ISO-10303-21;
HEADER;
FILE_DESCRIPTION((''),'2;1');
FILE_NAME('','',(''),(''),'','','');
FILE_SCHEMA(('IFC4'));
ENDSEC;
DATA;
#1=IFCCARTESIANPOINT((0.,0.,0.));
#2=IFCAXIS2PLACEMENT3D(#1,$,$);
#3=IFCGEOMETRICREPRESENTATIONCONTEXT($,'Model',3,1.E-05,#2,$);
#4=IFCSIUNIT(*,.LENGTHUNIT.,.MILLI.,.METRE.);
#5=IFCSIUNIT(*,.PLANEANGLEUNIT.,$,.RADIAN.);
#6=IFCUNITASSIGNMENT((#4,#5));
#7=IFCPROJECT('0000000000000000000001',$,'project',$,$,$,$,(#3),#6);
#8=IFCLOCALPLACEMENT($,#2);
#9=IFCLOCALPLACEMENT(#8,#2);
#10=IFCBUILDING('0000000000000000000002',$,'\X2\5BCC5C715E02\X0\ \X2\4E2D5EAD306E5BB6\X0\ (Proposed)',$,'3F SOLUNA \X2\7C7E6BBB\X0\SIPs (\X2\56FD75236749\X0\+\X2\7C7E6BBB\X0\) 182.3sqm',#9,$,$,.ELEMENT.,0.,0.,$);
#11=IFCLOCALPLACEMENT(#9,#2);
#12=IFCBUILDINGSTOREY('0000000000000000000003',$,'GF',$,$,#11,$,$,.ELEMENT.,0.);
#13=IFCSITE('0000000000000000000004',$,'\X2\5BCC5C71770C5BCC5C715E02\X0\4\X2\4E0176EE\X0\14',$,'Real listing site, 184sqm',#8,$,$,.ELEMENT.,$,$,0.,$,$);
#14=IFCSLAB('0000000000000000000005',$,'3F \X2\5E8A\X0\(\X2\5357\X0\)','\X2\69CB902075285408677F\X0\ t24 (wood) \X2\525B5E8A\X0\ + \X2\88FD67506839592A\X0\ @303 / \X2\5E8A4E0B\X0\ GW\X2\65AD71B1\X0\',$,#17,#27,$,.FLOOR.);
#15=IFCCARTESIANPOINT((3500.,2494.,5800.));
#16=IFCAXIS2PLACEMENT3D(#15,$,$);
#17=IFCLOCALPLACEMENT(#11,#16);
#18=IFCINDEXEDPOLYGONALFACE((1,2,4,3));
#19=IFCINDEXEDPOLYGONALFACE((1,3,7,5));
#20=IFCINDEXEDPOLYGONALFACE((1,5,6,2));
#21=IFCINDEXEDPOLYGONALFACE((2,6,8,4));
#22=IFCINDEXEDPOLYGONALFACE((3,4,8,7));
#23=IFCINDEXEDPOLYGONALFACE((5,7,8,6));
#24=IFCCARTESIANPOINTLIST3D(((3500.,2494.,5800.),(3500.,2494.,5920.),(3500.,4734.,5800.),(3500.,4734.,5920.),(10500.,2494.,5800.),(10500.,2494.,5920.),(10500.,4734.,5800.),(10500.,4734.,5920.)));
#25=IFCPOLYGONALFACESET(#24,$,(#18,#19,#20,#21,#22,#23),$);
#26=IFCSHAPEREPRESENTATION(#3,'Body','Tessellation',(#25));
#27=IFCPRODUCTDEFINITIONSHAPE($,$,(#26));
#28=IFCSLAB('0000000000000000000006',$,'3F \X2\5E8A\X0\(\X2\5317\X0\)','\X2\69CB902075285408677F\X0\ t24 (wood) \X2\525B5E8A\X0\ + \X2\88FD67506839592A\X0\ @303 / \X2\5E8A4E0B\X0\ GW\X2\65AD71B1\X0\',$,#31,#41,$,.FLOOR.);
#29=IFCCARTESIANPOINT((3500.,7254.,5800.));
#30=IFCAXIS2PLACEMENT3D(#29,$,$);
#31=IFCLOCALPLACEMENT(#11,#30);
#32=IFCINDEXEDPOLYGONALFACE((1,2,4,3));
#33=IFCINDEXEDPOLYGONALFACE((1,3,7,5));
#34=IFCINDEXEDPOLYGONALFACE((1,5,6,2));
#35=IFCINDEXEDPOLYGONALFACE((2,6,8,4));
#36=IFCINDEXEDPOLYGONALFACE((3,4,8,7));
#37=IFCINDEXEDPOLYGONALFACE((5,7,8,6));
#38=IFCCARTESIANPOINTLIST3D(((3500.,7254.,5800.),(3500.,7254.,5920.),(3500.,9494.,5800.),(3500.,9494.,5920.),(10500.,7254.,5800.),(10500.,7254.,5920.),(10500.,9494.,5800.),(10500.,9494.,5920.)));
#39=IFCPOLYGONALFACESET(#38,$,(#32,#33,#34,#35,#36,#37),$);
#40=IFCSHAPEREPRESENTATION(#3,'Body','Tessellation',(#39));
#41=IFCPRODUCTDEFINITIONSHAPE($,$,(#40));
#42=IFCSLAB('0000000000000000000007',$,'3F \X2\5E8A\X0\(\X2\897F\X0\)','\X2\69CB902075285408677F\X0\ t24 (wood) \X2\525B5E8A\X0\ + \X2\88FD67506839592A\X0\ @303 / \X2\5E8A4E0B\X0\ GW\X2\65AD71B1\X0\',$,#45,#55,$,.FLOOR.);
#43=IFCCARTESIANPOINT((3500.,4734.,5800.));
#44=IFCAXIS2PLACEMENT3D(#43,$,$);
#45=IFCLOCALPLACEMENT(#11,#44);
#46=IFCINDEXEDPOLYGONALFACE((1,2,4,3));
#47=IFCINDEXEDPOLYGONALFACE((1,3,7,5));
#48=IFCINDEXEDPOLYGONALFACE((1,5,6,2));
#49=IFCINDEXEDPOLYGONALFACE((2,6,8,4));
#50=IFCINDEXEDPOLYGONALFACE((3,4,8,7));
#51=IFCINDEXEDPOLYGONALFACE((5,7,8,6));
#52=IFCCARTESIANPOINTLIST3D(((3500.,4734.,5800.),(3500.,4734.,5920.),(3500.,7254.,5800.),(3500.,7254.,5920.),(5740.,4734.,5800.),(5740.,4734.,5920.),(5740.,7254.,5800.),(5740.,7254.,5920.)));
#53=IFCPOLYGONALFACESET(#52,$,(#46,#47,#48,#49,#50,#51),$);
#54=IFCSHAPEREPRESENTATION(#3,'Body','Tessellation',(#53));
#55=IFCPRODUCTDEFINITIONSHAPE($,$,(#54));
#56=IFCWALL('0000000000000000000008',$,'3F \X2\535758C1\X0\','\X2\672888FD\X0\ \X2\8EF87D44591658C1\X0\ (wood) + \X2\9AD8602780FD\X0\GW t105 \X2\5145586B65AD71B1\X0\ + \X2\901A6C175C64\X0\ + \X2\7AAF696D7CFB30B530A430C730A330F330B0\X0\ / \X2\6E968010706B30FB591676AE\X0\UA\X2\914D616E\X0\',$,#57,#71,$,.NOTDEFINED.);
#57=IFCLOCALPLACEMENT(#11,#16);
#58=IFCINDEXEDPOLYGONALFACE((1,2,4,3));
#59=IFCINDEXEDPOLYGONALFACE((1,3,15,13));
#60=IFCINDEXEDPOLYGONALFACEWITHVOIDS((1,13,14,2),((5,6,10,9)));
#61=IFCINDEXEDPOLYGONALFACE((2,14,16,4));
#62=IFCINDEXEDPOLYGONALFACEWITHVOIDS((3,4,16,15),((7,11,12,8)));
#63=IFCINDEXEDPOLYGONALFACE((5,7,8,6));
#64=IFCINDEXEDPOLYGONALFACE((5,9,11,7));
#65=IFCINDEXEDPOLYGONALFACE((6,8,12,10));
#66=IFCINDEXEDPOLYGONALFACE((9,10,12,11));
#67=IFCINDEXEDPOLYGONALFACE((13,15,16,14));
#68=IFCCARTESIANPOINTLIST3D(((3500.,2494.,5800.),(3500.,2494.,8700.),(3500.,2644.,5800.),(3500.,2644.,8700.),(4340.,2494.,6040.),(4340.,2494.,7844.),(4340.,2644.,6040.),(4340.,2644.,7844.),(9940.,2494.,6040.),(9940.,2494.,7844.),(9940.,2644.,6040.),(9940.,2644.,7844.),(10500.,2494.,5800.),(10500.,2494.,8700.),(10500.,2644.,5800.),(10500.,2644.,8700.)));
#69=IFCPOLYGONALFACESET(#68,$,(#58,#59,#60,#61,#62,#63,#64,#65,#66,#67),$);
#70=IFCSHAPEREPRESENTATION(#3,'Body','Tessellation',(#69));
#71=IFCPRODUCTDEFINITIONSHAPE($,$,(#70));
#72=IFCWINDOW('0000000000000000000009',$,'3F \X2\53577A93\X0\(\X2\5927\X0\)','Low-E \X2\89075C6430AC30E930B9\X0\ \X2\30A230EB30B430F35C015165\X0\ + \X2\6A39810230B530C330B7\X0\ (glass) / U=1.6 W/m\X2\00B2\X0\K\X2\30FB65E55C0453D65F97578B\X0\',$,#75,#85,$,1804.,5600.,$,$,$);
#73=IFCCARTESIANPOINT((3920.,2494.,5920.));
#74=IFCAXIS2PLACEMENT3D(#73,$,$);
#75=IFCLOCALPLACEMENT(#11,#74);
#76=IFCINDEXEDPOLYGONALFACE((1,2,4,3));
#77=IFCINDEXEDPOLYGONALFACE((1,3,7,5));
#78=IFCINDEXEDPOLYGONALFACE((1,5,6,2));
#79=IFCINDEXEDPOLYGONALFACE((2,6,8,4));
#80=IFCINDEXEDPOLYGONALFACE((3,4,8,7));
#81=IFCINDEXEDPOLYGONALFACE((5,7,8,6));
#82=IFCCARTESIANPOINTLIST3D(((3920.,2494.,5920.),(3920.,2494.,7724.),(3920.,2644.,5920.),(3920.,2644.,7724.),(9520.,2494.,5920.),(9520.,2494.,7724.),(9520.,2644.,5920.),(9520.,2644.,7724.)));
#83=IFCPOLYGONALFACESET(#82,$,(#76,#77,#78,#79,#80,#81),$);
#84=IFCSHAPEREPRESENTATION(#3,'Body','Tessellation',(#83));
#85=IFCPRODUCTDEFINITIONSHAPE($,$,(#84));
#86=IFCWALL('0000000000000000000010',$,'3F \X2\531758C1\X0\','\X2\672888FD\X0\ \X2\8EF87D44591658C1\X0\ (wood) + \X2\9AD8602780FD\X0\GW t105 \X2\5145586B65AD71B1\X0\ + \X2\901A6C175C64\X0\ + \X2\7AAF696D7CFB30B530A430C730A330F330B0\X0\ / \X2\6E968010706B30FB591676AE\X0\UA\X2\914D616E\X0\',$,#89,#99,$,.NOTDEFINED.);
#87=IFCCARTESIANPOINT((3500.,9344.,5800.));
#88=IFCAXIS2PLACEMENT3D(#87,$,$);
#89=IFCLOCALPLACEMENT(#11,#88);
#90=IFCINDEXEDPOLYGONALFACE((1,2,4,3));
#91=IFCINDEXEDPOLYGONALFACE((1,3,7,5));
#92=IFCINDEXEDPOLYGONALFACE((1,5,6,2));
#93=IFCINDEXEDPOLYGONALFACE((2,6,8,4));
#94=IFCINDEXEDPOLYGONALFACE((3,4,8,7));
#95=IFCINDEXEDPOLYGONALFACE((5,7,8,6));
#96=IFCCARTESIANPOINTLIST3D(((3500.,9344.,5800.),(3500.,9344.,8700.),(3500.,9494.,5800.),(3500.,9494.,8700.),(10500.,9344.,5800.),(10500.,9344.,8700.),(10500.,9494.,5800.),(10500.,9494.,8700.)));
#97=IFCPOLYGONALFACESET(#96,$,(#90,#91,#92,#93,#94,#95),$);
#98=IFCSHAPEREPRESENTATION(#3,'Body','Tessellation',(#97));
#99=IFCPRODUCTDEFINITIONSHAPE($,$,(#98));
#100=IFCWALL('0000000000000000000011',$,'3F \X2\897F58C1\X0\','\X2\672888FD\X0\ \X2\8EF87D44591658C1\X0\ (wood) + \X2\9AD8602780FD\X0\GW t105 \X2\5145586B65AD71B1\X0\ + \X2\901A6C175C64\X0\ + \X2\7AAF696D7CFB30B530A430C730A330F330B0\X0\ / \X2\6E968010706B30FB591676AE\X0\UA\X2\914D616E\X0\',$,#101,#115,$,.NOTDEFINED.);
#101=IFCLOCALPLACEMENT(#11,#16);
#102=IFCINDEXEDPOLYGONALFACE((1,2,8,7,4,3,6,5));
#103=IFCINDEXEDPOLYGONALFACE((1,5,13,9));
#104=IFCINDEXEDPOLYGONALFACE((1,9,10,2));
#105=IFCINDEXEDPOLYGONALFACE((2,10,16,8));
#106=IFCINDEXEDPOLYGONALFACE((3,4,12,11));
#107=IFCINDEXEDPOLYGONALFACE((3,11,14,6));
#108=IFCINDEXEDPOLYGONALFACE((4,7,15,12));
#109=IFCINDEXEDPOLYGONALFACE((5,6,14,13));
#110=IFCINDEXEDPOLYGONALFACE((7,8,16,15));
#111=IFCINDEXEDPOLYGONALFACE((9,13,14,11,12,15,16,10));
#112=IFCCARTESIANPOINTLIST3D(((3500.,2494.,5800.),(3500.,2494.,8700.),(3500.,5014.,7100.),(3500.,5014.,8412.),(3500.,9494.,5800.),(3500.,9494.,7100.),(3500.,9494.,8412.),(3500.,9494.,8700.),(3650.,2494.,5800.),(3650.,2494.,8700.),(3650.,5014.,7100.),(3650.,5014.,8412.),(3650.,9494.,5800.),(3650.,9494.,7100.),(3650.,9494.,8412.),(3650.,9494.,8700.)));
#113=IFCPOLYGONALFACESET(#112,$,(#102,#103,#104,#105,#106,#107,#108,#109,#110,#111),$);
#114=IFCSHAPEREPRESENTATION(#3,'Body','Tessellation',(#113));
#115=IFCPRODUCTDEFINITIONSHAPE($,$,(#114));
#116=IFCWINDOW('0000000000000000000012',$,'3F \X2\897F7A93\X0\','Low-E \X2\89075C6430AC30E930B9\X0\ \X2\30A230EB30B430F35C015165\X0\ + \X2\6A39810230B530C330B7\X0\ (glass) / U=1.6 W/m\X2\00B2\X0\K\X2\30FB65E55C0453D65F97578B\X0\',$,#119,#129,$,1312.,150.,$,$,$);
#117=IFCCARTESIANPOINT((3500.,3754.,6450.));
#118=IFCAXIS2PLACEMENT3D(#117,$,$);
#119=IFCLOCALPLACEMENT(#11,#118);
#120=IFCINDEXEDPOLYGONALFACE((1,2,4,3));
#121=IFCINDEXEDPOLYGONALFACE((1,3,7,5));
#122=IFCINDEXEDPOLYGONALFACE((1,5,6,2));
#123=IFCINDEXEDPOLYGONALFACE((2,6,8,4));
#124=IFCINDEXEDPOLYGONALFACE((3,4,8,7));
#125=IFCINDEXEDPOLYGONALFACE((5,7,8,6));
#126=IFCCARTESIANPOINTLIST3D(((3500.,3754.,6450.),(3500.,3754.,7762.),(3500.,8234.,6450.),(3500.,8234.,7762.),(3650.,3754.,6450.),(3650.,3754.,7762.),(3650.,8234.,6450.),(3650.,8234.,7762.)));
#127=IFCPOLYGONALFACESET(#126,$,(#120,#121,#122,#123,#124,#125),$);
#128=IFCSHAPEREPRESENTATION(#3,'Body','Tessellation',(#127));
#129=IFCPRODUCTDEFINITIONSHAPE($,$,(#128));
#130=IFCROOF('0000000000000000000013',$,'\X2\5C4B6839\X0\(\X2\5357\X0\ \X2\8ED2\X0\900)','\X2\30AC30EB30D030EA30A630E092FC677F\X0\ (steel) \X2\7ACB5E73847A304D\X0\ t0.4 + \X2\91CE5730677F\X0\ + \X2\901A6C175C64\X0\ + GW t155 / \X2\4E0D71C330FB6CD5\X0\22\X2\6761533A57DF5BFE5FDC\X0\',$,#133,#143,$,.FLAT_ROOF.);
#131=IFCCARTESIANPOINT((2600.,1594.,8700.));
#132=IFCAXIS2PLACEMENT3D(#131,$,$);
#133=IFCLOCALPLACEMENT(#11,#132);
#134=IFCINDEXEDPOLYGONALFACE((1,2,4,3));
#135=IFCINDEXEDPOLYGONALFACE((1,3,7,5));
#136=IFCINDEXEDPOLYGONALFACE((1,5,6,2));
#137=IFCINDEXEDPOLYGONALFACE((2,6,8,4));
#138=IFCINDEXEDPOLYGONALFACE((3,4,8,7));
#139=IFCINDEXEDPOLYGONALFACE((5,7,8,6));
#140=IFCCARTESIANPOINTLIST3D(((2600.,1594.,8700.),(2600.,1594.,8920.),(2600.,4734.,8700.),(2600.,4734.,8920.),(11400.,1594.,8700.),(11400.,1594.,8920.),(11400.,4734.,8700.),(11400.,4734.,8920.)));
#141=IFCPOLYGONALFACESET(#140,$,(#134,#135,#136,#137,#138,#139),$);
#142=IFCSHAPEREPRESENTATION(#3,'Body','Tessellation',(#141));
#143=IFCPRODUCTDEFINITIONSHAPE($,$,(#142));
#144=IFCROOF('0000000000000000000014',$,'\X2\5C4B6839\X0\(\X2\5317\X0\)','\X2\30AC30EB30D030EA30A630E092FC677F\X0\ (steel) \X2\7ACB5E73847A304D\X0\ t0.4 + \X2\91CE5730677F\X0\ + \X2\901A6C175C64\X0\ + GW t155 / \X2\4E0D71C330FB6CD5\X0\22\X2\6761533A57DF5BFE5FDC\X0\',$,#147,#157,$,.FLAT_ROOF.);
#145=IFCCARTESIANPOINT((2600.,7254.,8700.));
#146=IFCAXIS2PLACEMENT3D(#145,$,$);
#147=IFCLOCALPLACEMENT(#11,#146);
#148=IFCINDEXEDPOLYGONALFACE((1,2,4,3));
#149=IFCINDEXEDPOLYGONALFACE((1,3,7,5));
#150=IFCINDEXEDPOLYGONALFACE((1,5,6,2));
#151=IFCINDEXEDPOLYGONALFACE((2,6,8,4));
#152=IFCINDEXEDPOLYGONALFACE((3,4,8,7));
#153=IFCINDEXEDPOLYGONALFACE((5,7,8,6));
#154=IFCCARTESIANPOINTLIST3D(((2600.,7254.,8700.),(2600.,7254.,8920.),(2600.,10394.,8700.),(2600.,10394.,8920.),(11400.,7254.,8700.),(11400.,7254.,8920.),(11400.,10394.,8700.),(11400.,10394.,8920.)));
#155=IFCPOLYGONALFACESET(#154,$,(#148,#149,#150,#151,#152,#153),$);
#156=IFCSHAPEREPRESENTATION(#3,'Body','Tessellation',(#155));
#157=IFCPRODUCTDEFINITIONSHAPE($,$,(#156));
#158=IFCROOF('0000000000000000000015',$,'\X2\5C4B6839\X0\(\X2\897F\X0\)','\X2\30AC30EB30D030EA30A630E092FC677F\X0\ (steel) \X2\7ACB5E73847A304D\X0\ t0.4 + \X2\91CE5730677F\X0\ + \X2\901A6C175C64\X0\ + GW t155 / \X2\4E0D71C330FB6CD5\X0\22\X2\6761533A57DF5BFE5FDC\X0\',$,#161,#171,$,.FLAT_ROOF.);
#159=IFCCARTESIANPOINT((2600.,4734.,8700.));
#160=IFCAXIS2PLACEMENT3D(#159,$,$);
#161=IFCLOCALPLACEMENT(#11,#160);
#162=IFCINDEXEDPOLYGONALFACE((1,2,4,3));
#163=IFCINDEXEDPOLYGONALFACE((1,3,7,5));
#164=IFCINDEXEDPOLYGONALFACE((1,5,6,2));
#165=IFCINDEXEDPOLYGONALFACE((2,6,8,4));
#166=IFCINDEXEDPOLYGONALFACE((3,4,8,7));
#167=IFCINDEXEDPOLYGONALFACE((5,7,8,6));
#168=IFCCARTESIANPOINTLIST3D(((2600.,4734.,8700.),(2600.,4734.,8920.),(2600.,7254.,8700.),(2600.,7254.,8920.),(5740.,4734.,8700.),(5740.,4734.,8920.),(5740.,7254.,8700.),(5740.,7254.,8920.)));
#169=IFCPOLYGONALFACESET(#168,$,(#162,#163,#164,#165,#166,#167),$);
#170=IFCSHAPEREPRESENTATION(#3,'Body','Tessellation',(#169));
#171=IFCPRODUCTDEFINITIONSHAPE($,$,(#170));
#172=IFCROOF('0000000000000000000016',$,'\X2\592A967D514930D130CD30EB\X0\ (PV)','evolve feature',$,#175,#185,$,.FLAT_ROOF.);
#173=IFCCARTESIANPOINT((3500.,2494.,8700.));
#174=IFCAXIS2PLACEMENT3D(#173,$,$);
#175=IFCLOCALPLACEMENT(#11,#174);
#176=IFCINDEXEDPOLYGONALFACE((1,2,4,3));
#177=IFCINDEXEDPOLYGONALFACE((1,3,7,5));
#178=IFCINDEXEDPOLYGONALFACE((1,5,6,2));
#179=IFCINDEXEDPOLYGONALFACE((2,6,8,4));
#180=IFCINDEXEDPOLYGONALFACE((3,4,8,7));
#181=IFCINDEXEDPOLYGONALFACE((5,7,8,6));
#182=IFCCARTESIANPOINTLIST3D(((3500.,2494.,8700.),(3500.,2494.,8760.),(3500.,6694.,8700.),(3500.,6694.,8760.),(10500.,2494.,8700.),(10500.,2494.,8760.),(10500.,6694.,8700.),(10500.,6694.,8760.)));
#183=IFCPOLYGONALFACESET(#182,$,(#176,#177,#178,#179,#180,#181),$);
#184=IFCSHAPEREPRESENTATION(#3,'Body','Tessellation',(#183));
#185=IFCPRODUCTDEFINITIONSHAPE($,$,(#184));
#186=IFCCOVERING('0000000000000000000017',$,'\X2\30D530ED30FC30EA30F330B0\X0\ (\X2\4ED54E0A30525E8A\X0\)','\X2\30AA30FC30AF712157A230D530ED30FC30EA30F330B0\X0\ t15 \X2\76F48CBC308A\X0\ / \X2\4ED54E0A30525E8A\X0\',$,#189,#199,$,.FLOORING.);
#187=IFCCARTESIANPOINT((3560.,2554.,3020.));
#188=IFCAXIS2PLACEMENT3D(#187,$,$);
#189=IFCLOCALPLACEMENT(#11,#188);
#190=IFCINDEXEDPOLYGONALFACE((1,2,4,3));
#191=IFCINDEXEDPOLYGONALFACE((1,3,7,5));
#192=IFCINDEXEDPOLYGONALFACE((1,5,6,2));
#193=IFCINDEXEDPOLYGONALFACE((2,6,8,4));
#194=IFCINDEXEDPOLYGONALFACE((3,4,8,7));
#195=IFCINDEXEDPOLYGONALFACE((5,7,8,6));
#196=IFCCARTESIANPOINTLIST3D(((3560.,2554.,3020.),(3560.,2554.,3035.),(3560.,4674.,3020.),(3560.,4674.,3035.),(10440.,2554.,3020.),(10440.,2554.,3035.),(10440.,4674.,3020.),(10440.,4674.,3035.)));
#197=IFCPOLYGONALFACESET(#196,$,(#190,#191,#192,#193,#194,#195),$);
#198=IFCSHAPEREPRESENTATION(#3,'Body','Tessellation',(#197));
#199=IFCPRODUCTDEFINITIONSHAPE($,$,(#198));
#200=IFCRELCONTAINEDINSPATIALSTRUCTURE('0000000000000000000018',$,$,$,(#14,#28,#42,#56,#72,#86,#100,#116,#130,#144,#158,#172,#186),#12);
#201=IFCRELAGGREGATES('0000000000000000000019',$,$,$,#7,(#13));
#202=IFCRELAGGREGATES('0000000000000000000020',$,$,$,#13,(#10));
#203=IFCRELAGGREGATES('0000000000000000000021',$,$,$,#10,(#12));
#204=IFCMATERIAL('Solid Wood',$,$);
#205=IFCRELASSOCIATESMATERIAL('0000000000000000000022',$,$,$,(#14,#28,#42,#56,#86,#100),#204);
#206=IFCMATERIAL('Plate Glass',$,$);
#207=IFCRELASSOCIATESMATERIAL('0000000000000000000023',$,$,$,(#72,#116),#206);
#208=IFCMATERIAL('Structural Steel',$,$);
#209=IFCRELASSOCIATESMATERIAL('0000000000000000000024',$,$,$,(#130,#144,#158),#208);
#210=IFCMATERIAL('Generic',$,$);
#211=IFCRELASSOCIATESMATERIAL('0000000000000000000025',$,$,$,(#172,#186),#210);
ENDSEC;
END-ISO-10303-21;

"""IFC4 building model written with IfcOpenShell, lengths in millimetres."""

from ifc_helpers import new_model, si_unit, frame, frame_2d, origin, place, context, project, spatial, rectangle, extrude, material, element, fill, save


model = new_model("IFC4")

# Units and contexts
model_context = context("Model", 3, precision=1e-05, world=origin())
ifc_project = project(units=[si_unit("LENGTHUNIT", "METRE", prefix="MILLI"), si_unit("PLANEANGLEUNIT", "RADIAN")], contexts=[model_context])

# Site, building, storey
site_placement = place(None, origin())
site = spatial("IfcSite", under=ifc_project, at=site_placement, Name="富山県富山市4丁目14", ObjectType="Real listing site, 184sqm", CompositionType="ELEMENT", RefElevation=0.0)
building_placement = place(site_placement, origin())
building = spatial("IfcBuilding", under=site, at=building_placement, Name="富山市 中庭の家 (Proposed)", ObjectType="3F SOLUNA 籾殻SIPs (国産杉+籾殻) 182.3sqm", CompositionType="ELEMENT", ElevationOfRefHeight=0.0, ElevationOfTerrain=0.0)
storey_placement = place(building_placement, origin())
storey = spatial("IfcBuildingStorey", under=building, at=storey_placement, Name="GF", CompositionType="ELEMENT", Elevation=0.0)

# Slabs
ifc_material_1 = material(Name="Solid Wood")
slab_1_placement = place(storey_placement, frame((3500.0, 2494.0, 5800.0)))
element("IfcSlab", 1, at=slab_1_placement, inside=storey, material=ifc_material_1, Name="3F 床(南)", Description="構造用合板 t24 (wood) 剛床 + 製材根太 @303 / 床下 GW断熱", PredefinedType="FLOOR", context=model_context, shape_type="SweptSolid", body=[
    extrude(rectangle(XDim=7000.0, YDim=2240.0, at=frame_2d((3500.0, 1120.0))), frame((3500.0, 2494.0, 5800.0)), (0.0, 0.0, 1.0), 120.0),
])
slab_2_placement = place(storey_placement, frame((3500.0, 7254.0, 5800.0)))
element("IfcSlab", 2, at=slab_2_placement, inside=storey, material=ifc_material_1, Name="3F 床(北)", Description="構造用合板 t24 (wood) 剛床 + 製材根太 @303 / 床下 GW断熱", PredefinedType="FLOOR", context=model_context, shape_type="SweptSolid", body=[
    extrude(rectangle(XDim=7000.0, YDim=2240.0, at=frame_2d((3500.0, 1120.0))), frame((3500.0, 7254.0, 5800.0)), (0.0, 0.0, 1.0), 120.0),
])
slab_3_placement = place(storey_placement, frame((3500.0, 4734.0, 5800.0)))
element("IfcSlab", 3, at=slab_3_placement, inside=storey, material=ifc_material_1, Name="3F 床(西)", Description="構造用合板 t24 (wood) 剛床 + 製材根太 @303 / 床下 GW断熱", PredefinedType="FLOOR", context=model_context, shape_type="SweptSolid", body=[
    extrude(rectangle(XDim=2240.0, YDim=2520.0, at=frame_2d((1120.0, 1260.0))), frame((3500.0, 4734.0, 5800.0)), (0.0, 0.0, 1.0), 120.0),
])

# Wall, opening, window
wall_1_placement = place(storey_placement, frame((3500.0, 2494.0, 5800.0)))
wall_1 = element("IfcWall", 4, at=wall_1_placement, inside=storey, material=ifc_material_1, Name="3F 南壁", Description="木製 軸組外壁 (wood) + 高性能GW t105 充填断熱 + 通気層 + 窯業系サイディング / 準耐火・外皮UA配慮", PredefinedType="NOTDEFINED", context=model_context, shape_type="SweptSolid", body=[
    extrude(rectangle(XDim=7000.0, YDim=150.0, at=frame_2d((3500.0, 75.0))), frame((3500.0, 2494.0, 5800.0)), (0.0, 0.0, 1.0), 2900.0),
])
opening_1_placement = place(storey_placement, frame((3920.0, 2494.0, 5920.0)))
opening_1 = element("IfcOpeningElement", 5, at=opening_1_placement, cuts=wall_1, PredefinedType="NOTDEFINED", context=model_context, shape_type="SweptSolid", body=[
    extrude(rectangle(XDim=5600.0, YDim=150.0, at=frame_2d((2800.0, 75.0))), frame((3920.0, 2494.0, 5920.0)), (0.0, 0.0, 1.0), 1804.0),
])
ifc_material_2 = material(Name="Plate Glass")
window_1_placement = place(storey_placement, frame((3920.0, 2494.0, 5920.0)))
window_1 = element("IfcWindow", 6, at=window_1_placement, inside=storey, material=ifc_material_2, Name="3F 南窓(大)", Description="Low-E 複層ガラス アルゴン封入 + 樹脂サッシ (glass) / U=1.6 W/m²K・日射取得型", OverallHeight=1804.0, OverallWidth=5600.0, context=model_context, shape_type="SweptSolid", body=[
    extrude(rectangle(XDim=5600.0, YDim=150.0, at=frame_2d((2800.0, 75.0))), frame((3920.0, 2494.0, 5920.0)), (0.0, 0.0, 1.0), 1804.0),
])
fill(opening_1, window_1)

# Wall
wall_2_placement = place(storey_placement, frame((3500.0, 9344.0, 5800.0)))
element("IfcWall", 7, at=wall_2_placement, inside=storey, material=ifc_material_1, Name="3F 北壁", Description="木製 軸組外壁 (wood) + 高性能GW t105 充填断熱 + 通気層 + 窯業系サイディング / 準耐火・外皮UA配慮", PredefinedType="NOTDEFINED", context=model_context, shape_type="SweptSolid", body=[
    extrude(rectangle(XDim=7000.0, YDim=150.0, at=frame_2d((3500.0, 75.0))), frame((3500.0, 9344.0, 5800.0)), (0.0, 0.0, 1.0), 2900.0),
])

# Wall, opening, window
wall_3_placement = place(storey_placement, frame((3500.0, 2494.0, 5800.0)))
wall_3 = element("IfcWall", 8, at=wall_3_placement, inside=storey, material=ifc_material_1, Name="3F 西壁", Description="木製 軸組外壁 (wood) + 高性能GW t105 充填断熱 + 通気層 + 窯業系サイディング / 準耐火・外皮UA配慮", PredefinedType="NOTDEFINED", context=model_context, shape_type="SweptSolid", body=[
    extrude(rectangle(XDim=150.0, YDim=7000.0, at=frame_2d((75.0, 3500.0))), frame((3500.0, 2494.0, 5800.0)), (0.0, 0.0, 1.0), 2900.0),
])
opening_2_placement = place(storey_placement, frame((3500.0, 3754.0, 6450.0)))
opening_2 = element("IfcOpeningElement", 9, at=opening_2_placement, cuts=wall_3, PredefinedType="NOTDEFINED", context=model_context, shape_type="SweptSolid", body=[
    extrude(rectangle(XDim=150.0, YDim=4480.0, at=frame_2d((75.0, 2240.0))), frame((3500.0, 3754.0, 6450.0)), (0.0, 0.0, 1.0), 1312.0),
])
window_2_placement = place(storey_placement, frame((3500.0, 3754.0, 6450.0)))
window_2 = element("IfcWindow", 10, at=window_2_placement, inside=storey, material=ifc_material_2, Name="3F 西窓", Description="Low-E 複層ガラス アルゴン封入 + 樹脂サッシ (glass) / U=1.6 W/m²K・日射取得型", OverallHeight=1312.0, OverallWidth=150.0, context=model_context, shape_type="SweptSolid", body=[
    extrude(rectangle(XDim=150.0, YDim=4480.0, at=frame_2d((75.0, 2240.0))), frame((3500.0, 3754.0, 6450.0)), (0.0, 0.0, 1.0), 1312.0),
])
fill(opening_2, window_2)

# Roofs
ifc_material_3 = material(Name="Structural Steel")
roof_1_placement = place(storey_placement, frame((2600.0, 1594.0, 8700.0)))
element("IfcRoof", 11, at=roof_1_placement, inside=storey, material=ifc_material_3, Name="屋根(南 軒900)", Description="ガルバリウム鋼板 (steel) 立平葺き t0.4 + 野地板 + 通気層 + GW t155 / 不燃・法22条区域対応", PredefinedType="FLAT_ROOF", context=model_context, shape_type="SweptSolid", body=[
    extrude(rectangle(XDim=8800.0, YDim=3140.0, at=frame_2d((4400.0, 1570.0))), frame((2600.0, 1594.0, 8700.0)), (0.0, 0.0, 1.0), 220.0),
])
roof_2_placement = place(storey_placement, frame((2600.0, 7254.0, 8700.0)))
element("IfcRoof", 12, at=roof_2_placement, inside=storey, material=ifc_material_3, Name="屋根(北)", Description="ガルバリウム鋼板 (steel) 立平葺き t0.4 + 野地板 + 通気層 + GW t155 / 不燃・法22条区域対応", PredefinedType="FLAT_ROOF", context=model_context, shape_type="SweptSolid", body=[
    extrude(rectangle(XDim=8800.0, YDim=3140.0, at=frame_2d((4400.0, 1570.0))), frame((2600.0, 7254.0, 8700.0)), (0.0, 0.0, 1.0), 220.0),
])
roof_3_placement = place(storey_placement, frame((2600.0, 4734.0, 8700.0)))
element("IfcRoof", 13, at=roof_3_placement, inside=storey, material=ifc_material_3, Name="屋根(西)", Description="ガルバリウム鋼板 (steel) 立平葺き t0.4 + 野地板 + 通気層 + GW t155 / 不燃・法22条区域対応", PredefinedType="FLAT_ROOF", context=model_context, shape_type="SweptSolid", body=[
    extrude(rectangle(XDim=3140.0, YDim=2520.0, at=frame_2d((1570.0, 1260.0))), frame((2600.0, 4734.0, 8700.0)), (0.0, 0.0, 1.0), 220.0),
])
ifc_material_4 = material(Name="Generic")
roof_4_placement = place(storey_placement, frame((3500.0, 2494.0, 8700.0)))
element("IfcRoof", 14, at=roof_4_placement, inside=storey, material=ifc_material_4, Name="太陽光パネル (PV)", Description="evolve feature", PredefinedType="FLAT_ROOF", context=model_context, shape_type="SweptSolid", body=[
    extrude(rectangle(XDim=7000.0, YDim=4200.0, at=frame_2d((3500.0, 2100.0))), frame((3500.0, 2494.0, 8700.0)), (0.0, 0.0, 1.0), 60.0),
])

# Covering
covering_1_placement = place(storey_placement, frame((3560.0, 2554.0, 3020.0)))
element("IfcCovering", 15, at=covering_1_placement, inside=storey, material=ifc_material_4, Name="フローリング (仕上げ床)", Description="オーク無垢フローリング t15 直貼り / 仕上げ床", PredefinedType="FLOORING", context=model_context, shape_type="SweptSolid", body=[
    extrude(rectangle(XDim=6880.0, YDim=2120.0, at=frame_2d((3440.0, 1060.0))), frame((3560.0, 2554.0, 3020.0)), (0.0, 0.0, 1.0), 15.0),
])

save(model, "model.ifc")
